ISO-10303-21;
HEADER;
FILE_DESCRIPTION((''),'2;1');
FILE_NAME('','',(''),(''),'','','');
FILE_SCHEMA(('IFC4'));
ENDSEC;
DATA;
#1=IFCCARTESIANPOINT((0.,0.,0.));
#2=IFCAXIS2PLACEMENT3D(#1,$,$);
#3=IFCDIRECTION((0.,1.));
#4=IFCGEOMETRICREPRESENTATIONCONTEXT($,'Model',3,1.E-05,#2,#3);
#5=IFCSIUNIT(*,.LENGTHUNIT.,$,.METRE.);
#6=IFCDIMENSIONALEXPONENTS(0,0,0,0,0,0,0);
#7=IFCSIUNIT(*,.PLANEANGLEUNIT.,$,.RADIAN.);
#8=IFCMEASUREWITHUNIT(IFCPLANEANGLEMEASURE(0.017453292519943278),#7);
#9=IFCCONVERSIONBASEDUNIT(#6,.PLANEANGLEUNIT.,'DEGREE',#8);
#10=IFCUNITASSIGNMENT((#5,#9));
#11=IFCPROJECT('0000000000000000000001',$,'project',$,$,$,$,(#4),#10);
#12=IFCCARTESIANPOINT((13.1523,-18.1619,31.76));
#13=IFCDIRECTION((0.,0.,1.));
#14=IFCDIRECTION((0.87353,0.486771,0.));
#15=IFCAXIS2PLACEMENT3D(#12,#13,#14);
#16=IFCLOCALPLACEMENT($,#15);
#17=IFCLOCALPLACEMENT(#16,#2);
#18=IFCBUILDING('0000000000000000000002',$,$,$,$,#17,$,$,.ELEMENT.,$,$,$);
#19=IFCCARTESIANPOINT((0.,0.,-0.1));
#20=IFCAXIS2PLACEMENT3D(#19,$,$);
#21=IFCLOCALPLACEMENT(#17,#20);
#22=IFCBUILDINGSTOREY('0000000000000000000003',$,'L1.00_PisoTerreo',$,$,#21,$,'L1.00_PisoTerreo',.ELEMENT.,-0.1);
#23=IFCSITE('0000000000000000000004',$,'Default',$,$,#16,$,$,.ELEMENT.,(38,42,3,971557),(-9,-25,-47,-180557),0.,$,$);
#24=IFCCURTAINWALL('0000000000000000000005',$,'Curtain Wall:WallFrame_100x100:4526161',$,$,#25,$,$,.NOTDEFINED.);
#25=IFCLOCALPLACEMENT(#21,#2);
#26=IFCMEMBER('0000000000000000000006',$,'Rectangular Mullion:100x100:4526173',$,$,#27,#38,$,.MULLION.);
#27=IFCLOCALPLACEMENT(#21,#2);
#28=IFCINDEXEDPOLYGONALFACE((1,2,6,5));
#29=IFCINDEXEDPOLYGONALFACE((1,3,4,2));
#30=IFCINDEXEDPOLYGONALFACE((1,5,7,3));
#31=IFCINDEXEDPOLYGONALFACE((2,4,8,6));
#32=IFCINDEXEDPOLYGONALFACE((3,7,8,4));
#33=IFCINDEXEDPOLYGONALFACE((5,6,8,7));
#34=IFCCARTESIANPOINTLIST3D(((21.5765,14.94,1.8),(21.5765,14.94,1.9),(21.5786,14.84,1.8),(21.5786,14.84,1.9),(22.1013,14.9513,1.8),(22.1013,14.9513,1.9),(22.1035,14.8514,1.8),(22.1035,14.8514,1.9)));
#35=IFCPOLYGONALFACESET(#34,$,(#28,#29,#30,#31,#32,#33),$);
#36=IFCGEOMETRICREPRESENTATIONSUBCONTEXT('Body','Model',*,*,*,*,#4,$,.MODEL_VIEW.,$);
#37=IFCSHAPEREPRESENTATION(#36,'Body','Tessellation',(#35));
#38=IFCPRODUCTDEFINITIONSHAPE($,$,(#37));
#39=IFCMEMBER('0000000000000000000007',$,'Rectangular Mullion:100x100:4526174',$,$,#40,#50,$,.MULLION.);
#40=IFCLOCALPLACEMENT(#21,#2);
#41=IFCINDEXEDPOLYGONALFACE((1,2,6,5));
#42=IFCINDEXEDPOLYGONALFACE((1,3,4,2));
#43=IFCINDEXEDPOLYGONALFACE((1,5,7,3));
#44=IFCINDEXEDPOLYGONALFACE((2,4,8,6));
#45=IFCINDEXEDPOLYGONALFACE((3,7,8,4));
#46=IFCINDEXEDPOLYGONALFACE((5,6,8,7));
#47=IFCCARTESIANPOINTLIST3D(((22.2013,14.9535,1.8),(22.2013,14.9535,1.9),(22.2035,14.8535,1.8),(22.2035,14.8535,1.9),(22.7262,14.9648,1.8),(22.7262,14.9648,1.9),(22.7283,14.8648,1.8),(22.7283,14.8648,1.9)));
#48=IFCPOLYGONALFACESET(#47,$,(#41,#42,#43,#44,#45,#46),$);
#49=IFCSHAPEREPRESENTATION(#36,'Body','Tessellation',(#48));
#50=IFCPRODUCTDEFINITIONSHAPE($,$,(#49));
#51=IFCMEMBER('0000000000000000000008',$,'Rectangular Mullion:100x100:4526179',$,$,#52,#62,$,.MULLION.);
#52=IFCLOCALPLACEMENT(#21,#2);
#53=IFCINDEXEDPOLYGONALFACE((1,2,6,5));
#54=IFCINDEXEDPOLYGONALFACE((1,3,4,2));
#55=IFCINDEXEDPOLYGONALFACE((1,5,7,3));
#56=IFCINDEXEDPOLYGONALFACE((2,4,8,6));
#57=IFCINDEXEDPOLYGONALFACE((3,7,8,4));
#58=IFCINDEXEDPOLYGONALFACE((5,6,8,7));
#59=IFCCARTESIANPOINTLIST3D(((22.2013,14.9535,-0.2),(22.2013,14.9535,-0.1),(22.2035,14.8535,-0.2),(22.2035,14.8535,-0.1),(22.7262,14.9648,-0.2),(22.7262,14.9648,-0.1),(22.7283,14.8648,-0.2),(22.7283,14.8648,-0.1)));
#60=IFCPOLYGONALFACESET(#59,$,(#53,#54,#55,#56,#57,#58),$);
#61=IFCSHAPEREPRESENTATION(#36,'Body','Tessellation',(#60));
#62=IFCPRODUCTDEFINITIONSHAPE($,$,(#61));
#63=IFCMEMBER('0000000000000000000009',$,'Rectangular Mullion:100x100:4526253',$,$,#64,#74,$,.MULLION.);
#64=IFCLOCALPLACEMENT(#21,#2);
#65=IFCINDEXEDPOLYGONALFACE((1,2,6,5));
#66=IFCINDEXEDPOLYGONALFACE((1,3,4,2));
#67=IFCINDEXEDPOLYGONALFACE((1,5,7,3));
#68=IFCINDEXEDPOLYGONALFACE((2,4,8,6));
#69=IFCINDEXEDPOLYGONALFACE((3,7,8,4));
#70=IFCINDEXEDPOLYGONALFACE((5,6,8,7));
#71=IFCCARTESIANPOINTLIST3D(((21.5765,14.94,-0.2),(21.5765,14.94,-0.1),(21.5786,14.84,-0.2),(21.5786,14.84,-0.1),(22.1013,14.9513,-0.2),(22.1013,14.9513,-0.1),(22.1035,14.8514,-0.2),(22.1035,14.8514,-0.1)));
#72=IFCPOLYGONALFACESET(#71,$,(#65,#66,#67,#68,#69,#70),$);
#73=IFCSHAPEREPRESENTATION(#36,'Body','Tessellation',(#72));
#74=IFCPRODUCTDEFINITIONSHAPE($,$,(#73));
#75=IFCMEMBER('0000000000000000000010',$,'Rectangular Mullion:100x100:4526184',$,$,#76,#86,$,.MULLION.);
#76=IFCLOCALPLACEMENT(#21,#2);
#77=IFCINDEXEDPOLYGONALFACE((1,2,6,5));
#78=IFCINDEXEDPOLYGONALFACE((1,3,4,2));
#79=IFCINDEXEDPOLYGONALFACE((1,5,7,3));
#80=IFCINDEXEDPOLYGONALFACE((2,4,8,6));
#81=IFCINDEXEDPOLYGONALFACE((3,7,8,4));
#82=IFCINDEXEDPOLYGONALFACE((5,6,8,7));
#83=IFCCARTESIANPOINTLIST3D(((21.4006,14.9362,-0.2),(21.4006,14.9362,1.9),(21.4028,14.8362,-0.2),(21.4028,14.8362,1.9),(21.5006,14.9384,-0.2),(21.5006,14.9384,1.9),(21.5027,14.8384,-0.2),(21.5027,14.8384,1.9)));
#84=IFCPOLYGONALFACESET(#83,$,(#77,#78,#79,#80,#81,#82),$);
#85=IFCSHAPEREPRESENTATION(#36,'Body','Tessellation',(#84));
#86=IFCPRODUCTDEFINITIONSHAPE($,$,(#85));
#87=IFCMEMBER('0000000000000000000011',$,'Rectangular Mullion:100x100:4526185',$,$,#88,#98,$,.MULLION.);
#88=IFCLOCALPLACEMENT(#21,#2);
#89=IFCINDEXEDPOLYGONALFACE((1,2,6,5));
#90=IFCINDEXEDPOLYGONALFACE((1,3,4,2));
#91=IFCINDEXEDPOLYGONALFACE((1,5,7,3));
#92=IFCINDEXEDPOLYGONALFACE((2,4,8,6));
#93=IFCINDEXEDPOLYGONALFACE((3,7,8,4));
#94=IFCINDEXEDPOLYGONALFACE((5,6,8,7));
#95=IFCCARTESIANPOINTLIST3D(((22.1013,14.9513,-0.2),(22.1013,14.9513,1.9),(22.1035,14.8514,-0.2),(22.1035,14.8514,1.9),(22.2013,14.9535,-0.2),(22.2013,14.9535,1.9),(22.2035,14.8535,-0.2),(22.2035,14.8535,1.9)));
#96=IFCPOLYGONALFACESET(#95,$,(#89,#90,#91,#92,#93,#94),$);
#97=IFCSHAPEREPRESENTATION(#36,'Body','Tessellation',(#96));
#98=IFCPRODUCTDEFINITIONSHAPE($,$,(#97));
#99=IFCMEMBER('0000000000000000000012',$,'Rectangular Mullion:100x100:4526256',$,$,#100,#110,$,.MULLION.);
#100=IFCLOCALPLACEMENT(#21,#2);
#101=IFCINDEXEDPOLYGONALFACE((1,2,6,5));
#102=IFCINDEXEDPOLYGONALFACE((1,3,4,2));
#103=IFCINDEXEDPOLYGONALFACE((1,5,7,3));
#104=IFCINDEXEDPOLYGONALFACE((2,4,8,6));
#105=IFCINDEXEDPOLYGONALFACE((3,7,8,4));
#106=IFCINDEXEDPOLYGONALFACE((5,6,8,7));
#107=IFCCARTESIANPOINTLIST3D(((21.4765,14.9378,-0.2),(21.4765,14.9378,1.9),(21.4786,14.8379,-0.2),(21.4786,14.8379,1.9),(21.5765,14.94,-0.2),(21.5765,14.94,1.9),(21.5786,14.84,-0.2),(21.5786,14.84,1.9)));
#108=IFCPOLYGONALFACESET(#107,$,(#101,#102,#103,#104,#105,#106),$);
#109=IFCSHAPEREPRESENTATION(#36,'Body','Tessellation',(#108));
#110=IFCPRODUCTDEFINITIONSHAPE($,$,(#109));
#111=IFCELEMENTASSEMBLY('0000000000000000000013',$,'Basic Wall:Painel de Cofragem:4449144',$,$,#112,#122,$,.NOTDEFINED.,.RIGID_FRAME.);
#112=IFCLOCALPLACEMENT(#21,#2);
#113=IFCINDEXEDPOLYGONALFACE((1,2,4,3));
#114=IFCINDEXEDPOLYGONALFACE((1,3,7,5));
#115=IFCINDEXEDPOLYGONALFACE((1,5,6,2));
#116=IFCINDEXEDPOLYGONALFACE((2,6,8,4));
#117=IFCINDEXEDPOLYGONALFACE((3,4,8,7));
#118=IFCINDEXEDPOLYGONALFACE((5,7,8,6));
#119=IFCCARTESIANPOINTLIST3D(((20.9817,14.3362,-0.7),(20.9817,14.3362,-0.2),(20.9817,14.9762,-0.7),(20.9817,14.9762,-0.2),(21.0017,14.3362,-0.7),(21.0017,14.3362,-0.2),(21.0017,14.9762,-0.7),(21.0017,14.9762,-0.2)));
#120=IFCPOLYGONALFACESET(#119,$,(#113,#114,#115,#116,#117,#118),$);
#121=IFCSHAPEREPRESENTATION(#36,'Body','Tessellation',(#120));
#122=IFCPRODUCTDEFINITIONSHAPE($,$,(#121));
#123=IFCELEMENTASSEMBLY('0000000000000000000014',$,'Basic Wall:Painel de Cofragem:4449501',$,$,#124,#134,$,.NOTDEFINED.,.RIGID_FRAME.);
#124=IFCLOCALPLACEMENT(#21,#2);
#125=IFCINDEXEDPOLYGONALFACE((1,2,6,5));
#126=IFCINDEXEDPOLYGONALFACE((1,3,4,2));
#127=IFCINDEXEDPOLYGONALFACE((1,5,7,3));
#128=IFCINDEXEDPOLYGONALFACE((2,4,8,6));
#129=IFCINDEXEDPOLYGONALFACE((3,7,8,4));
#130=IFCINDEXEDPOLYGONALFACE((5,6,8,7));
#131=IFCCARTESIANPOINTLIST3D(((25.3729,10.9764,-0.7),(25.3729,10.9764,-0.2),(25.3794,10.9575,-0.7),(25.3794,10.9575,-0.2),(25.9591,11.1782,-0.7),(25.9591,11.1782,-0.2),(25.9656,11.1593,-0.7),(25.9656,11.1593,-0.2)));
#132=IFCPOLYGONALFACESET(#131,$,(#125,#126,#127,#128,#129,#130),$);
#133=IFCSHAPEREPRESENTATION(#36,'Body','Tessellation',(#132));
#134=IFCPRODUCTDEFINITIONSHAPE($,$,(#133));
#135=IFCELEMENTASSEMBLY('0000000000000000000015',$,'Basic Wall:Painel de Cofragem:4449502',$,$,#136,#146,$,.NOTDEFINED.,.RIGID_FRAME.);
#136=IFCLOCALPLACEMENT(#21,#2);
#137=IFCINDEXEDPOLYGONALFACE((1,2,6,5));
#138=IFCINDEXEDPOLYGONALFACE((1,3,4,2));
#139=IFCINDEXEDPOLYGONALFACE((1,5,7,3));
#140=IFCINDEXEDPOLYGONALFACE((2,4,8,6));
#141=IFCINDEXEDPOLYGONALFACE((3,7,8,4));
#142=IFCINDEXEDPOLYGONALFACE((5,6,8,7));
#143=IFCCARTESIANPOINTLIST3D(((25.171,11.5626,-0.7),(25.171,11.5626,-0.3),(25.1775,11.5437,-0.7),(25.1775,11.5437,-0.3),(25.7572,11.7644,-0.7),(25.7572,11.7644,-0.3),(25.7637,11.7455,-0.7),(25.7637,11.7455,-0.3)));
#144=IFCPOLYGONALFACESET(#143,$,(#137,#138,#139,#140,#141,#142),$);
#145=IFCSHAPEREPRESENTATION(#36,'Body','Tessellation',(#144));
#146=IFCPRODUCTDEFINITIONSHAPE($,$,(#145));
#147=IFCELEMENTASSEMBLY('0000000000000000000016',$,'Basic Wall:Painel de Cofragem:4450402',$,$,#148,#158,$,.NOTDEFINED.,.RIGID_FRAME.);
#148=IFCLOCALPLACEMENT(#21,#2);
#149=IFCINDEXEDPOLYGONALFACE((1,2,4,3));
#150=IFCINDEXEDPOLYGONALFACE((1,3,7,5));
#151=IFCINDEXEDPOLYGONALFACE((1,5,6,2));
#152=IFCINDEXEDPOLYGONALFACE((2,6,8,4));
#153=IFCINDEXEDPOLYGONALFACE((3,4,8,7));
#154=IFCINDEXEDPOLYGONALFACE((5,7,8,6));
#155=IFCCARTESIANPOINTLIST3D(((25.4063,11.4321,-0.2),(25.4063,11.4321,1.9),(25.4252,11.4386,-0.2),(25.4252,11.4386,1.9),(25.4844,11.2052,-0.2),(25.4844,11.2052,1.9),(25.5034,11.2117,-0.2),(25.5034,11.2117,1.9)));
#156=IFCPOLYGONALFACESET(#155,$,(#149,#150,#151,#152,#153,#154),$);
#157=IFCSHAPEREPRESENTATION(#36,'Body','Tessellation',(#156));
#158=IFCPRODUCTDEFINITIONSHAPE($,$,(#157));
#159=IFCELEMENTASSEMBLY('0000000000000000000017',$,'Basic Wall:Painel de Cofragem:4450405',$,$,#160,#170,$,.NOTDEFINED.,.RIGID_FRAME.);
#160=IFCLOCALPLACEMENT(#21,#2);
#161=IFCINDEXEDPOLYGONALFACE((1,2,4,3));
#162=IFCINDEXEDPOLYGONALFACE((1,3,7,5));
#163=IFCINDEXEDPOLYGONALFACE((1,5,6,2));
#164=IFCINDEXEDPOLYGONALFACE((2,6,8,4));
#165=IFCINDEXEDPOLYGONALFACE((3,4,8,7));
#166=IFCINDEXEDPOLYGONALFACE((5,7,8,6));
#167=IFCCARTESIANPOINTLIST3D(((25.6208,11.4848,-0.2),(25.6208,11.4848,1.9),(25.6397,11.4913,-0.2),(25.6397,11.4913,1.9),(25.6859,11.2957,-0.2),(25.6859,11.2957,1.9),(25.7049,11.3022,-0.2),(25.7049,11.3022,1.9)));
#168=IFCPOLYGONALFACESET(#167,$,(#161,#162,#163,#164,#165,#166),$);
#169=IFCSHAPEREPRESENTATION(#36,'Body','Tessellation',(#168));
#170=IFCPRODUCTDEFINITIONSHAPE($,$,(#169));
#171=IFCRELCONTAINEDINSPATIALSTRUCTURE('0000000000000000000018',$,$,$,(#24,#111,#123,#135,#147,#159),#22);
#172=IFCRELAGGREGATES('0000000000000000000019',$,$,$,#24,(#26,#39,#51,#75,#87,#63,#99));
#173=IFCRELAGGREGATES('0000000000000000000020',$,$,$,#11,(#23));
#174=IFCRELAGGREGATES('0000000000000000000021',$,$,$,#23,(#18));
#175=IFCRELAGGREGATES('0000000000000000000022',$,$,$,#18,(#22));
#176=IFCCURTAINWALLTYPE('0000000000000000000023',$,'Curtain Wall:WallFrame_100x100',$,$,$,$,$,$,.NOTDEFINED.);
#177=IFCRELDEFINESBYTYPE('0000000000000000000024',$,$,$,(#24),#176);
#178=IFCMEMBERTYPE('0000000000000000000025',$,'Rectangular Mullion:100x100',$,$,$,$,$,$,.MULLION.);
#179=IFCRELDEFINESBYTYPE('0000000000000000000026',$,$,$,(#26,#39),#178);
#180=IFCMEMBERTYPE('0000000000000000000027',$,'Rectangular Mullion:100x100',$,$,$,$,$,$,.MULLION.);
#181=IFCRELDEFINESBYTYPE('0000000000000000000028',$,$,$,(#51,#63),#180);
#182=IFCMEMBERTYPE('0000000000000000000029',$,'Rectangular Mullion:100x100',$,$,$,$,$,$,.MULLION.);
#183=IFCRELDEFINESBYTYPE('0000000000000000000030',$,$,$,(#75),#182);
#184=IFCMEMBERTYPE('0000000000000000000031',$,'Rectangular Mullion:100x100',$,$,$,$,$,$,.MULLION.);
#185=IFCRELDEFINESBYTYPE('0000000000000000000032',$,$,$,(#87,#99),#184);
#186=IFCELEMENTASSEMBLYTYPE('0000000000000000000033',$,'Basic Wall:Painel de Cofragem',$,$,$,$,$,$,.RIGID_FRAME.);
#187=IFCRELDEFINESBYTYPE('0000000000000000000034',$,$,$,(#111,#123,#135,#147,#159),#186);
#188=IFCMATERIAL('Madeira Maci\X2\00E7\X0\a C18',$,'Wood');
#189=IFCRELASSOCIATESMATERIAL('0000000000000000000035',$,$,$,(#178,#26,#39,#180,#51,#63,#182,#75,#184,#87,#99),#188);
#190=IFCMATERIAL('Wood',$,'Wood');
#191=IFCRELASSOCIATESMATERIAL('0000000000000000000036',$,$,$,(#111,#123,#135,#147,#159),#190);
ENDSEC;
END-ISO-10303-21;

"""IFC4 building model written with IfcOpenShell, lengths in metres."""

from ifc_helpers import new_model, entity, si_unit, converted_unit, direction, frame, origin, place, context, subcontext, project, spatial, indexed_curve, outline, extrude, source, transform, mapped, material, type_object, type_shapes, element, aggregate, save


model = new_model("IFC4")

# Units and contexts
model_context = context("Model", 3, precision=1e-05, world=origin(), true_north=direction((0.0, 1.0)))
body_context = subcontext(model_context, "Body", "Model", "MODEL_VIEW")
ifc_project = project(units=[si_unit("LENGTHUNIT", "METRE"), converted_unit("PLANEANGLEUNIT", "DEGREE", entity("IfcPlaneAngleMeasure", 0.017453292519943278), si_unit("PLANEANGLEUNIT", "RADIAN"), dimensions=[0, 0, 0, 0, 0, 0, 0])], contexts=[model_context])

# Site, building, storey
site_placement = place(None, frame((13.1523, -18.1619, 31.76), z_axis=(0.0, 0.0, 1.0), x_axis=(0.87353, 0.486771, 0.0)))
site = spatial("IfcSite", under=ifc_project, at=site_placement, Name="Default", CompositionType="ELEMENT", RefLatitude=(38, 42, 3, 971557), RefLongitude=(-9, -25, -47, -180557), RefElevation=0.0)
building_placement = place(site_placement, origin())
building = spatial("IfcBuilding", under=site, at=building_placement, CompositionType="ELEMENT")
storey_placement = place(building_placement, frame((0.0, 0.0, -0.1)))
storey = spatial("IfcBuildingStorey", under=building, at=storey_placement, Name="L1.00_PisoTerreo", LongName="L1.00_PisoTerreo", CompositionType="ELEMENT", Elevation=-0.1)

# Curtain wall, members
curtain_wall_type = type_object("IfcCurtainWallType", Name="Curtain Wall:WallFrame_100x100", PredefinedType="NOTDEFINED")
curtain_wall_placement = place(storey_placement, frame((0.0, 0.0, 0.1)))
curtain_wall = element("IfcCurtainWall", 1, at=curtain_wall_placement, inside=storey, type_object=curtain_wall_type, Name="Curtain Wall:WallFrame_100x100:4526161", PredefinedType="NOTDEFINED")
ifc_material_1 = material(Name="Madeira Maciça C18", Category="Wood")
member_type_1 = type_object("IfcMemberType", Name="Rectangular Mullion:100x100", PredefinedType="MULLION", material=ifc_material_1)
shared_shape_1 = source(origin(), body_context, "Body", "SweptSolid", [
    extrude(outline(indexed_curve([(-0.05, -0.05), (0.05, -0.05), (0.05, 0.05), (-0.05, 0.05), (-0.05, -0.05)], self_intersect=False)), frame((-0.05, 0.0, -0.525), z_axis=(0.0, 0.0, 1.0), x_axis=(-1.0, 0.0, 0.0)), (0.0, 0.0, 1.0), 0.525),
])
type_shapes(member_type_1, [shared_shape_1])
member_1_placement = place(curtain_wall_placement, frame((22.1024, 14.9013, 1.8), z_axis=(0.999767, 0.021581, 0.0), x_axis=(0.0, 0.0, 1.0)))
member_1 = element("IfcMember", 2, at=member_1_placement, type_object=member_type_1, material=ifc_material_1, Name="Rectangular Mullion:100x100:4526173", PredefinedType="MULLION", context=body_context, shape_type="MappedRepresentation", body=[
    mapped(shared_shape_1, transform((0.0, 0.0, 0.0), scale=1.0)),
])
member_2_placement = place(curtain_wall_placement, frame((22.7273, 14.9148, 1.8), z_axis=(0.999767, 0.021581, 0.0), x_axis=(0.0, 0.0, 1.0)))
member_2 = element("IfcMember", 3, at=member_2_placement, type_object=member_type_1, material=ifc_material_1, Name="Rectangular Mullion:100x100:4526174", PredefinedType="MULLION", context=body_context, shape_type="MappedRepresentation", body=[
    mapped(shared_shape_1, transform((0.0, 0.0, 0.0), scale=1.0)),
])
member_type_2 = type_object("IfcMemberType", Name="Rectangular Mullion:100x100", PredefinedType="MULLION", material=ifc_material_1)
shared_shape_2 = source(origin(), body_context, "Body", "SweptSolid", [
    extrude(outline(indexed_curve([(-0.05, -0.05), (0.05, -0.05), (0.05, 0.05), (-0.05, 0.05), (-0.05, -0.05)], self_intersect=False)), frame((-0.05, 0.0, -0.525), z_axis=(0.0, 0.0, 1.0), x_axis=(0.0, -1.0, 0.0)), (0.0, 0.0, 1.0), 0.525),
])
type_shapes(member_type_2, [shared_shape_2])
member_3_placement = place(curtain_wall_placement, frame((22.2024, 14.9035, -0.3), z_axis=(-0.999767, -0.021581, 0.0), x_axis=(0.0, 0.0, -1.0)))
member_3 = element("IfcMember", 4, at=member_3_placement, type_object=member_type_2, material=ifc_material_1, Name="Rectangular Mullion:100x100:4526179", PredefinedType="MULLION", context=body_context, shape_type="MappedRepresentation", body=[
    mapped(shared_shape_2, transform((0.0, 0.0, 0.0), scale=1.0)),
])
member_4_placement = place(curtain_wall_placement, frame((21.5775, 14.89, -0.3), z_axis=(-0.999767, -0.021581, 0.0), x_axis=(0.0, 0.0, -1.0)))
member_4 = element("IfcMember", 5, at=member_4_placement, type_object=member_type_2, material=ifc_material_1, Name="Rectangular Mullion:100x100:4526253", PredefinedType="MULLION", context=body_context, shape_type="MappedRepresentation", body=[
    mapped(shared_shape_2, transform((0.0, 0.0, 0.0), scale=1.0)),
])
member_type_3 = type_object("IfcMemberType", Name="Rectangular Mullion:100x100", PredefinedType="MULLION", material=ifc_material_1)
shared_shape_3 = source(origin(), body_context, "Body", "SweptSolid", [
    extrude(outline(indexed_curve([(-0.05, -0.05), (0.05, -0.05), (0.05, 0.05), (-0.05, 0.05), (-0.05, -0.05)], self_intersect=False)), frame((-0.05, 0.0, -2.1), z_axis=(0.0, 0.0, 1.0), x_axis=(0.0, -1.0, 0.0)), (0.0, 0.0, 1.0), 2.1),
])
type_shapes(member_type_3, [shared_shape_3])
member_5_placement = place(curtain_wall_placement, frame((21.4017, 14.8862, 1.8), z_axis=(0.0, 0.0, 1.0), x_axis=(-0.999767, -0.021581, 0.0)))
member_5 = element("IfcMember", 6, at=member_5_placement, type_object=member_type_3, material=ifc_material_1, Name="Rectangular Mullion:100x100:4526184", PredefinedType="MULLION", context=body_context, shape_type="MappedRepresentation", body=[
    mapped(shared_shape_3, transform((0.0, 0.0, 0.0), scale=1.0)),
])
member_type_4 = type_object("IfcMemberType", Name="Rectangular Mullion:100x100", PredefinedType="MULLION", material=ifc_material_1)
shared_shape_4 = source(origin(), body_context, "Body", "SweptSolid", [
    extrude(outline(indexed_curve([(-0.05, -0.05), (0.05, -0.05), (0.05, 0.05), (-0.05, 0.05), (-0.05, -0.05)], self_intersect=False)), frame((0.0, 0.0, -2.1), z_axis=(0.0, 0.0, 1.0), x_axis=(-1.0, 0.0, 0.0)), (0.0, 0.0, 1.0), 2.1),
])
type_shapes(member_type_4, [shared_shape_4])
member_6_placement = place(curtain_wall_placement, frame((22.1524, 14.9024, -0.3), z_axis=(0.0, 0.0, -1.0), x_axis=(0.999767, 0.021581, 0.0)))
member_6 = element("IfcMember", 7, at=member_6_placement, type_object=member_type_4, material=ifc_material_1, Name="Rectangular Mullion:100x100:4526185", PredefinedType="MULLION", context=body_context, shape_type="MappedRepresentation", body=[
    mapped(shared_shape_4, transform((0.0, 0.0, 0.0), scale=1.0)),
])
member_7_placement = place(curtain_wall_placement, frame((21.5275, 14.8889, -0.3), z_axis=(0.0, 0.0, -1.0), x_axis=(0.999767, 0.021581, 0.0)))
member_7 = element("IfcMember", 8, at=member_7_placement, type_object=member_type_4, material=ifc_material_1, Name="Rectangular Mullion:100x100:4526256", PredefinedType="MULLION", context=body_context, shape_type="MappedRepresentation", body=[
    mapped(shared_shape_4, transform((0.0, 0.0, 0.0), scale=1.0)),
])
aggregate(curtain_wall, [member_1, member_2, member_3, member_5, member_6, member_4, member_7])

# Element assemblies
ifc_material_2 = material(Name="Wood", Category="Wood")
element_assembly_type = type_object("IfcElementAssemblyType", Name="Basic Wall:Painel de Cofragem", PredefinedType="RIGID_FRAME")
assembly_1_placement = place(storey_placement, frame((20.9917, 14.3362, -0.7), z_axis=(0.0, 0.0, 1.0), x_axis=(0.0, 1.0, 0.0)))
element("IfcElementAssembly", 9, at=assembly_1_placement, inside=storey, type_object=element_assembly_type, material=ifc_material_2, Name="Basic Wall:Painel de Cofragem:4449144", AssemblyPlace="NOTDEFINED", PredefinedType="RIGID_FRAME", context=body_context, shape_type="SweptSolid", body=[
    extrude(outline(indexed_curve([(0.64, 0.01), (0.0, 0.01), (0.0, -0.01), (0.64, -0.01), (0.64, 0.01)], self_intersect=False)), origin(), (0.0, 0.0, 1.0), 0.5),
])
assembly_2_placement = place(storey_placement, frame((25.3761, 10.9669, -0.7), z_axis=(0.0, 0.0, 1.0), x_axis=(0.945519, 0.325568, 0.0)))
element("IfcElementAssembly", 10, at=assembly_2_placement, inside=storey, type_object=element_assembly_type, material=ifc_material_2, Name="Basic Wall:Painel de Cofragem:4449501", AssemblyPlace="NOTDEFINED", PredefinedType="RIGID_FRAME", context=body_context, shape_type="SweptSolid", body=[
    extrude(outline(indexed_curve([(0.62, 0.01), (0.0, 0.01), (0.0, -0.01), (0.62, -0.01), (0.62, 0.01)], self_intersect=False)), origin(), (0.0, 0.0, 1.0), 0.5),
])
assembly_3_placement = place(storey_placement, frame((25.1743, 11.5531, -0.7), z_axis=(0.0, 0.0, 1.0), x_axis=(0.945519, 0.325568, 0.0)))
element("IfcElementAssembly", 11, at=assembly_3_placement, inside=storey, type_object=element_assembly_type, material=ifc_material_2, Name="Basic Wall:Painel de Cofragem:4449502", AssemblyPlace="NOTDEFINED", PredefinedType="RIGID_FRAME", context=body_context, shape_type="SweptSolid", body=[
    extrude(outline(indexed_curve([(0.62, 0.01), (0.0, 0.01), (0.0, -0.01), (0.62, -0.01), (0.62, 0.01)], self_intersect=False)), origin(), (0.0, 0.0, 1.0), 0.4),
])
assembly_4_placement = place(storey_placement, frame((25.4158, 11.4353, -0.2), z_axis=(0.0, 0.0, 1.0), x_axis=(0.325568, -0.945519, 0.0)))
element("IfcElementAssembly", 12, at=assembly_4_placement, inside=storey, type_object=element_assembly_type, material=ifc_material_2, Name="Basic Wall:Painel de Cofragem:4450402", AssemblyPlace="NOTDEFINED", PredefinedType="RIGID_FRAME", context=body_context, shape_type="SweptSolid", body=[
    extrude(outline(indexed_curve([(0.24, 0.01), (0.0, 0.01), (0.0, -0.01), (0.24, -0.01), (0.24, 0.01)], self_intersect=False)), origin(), (0.0, 0.0, 1.0), 2.1),
])
assembly_5_placement = place(storey_placement, frame((25.6303, 11.4881, -0.2), z_axis=(0.0, 0.0, 1.0), x_axis=(0.325568, -0.945519, 0.0)))
element("IfcElementAssembly", 13, at=assembly_5_placement, inside=storey, type_object=element_assembly_type, material=ifc_material_2, Name="Basic Wall:Painel de Cofragem:4450405", AssemblyPlace="NOTDEFINED", PredefinedType="RIGID_FRAME", context=body_context, shape_type="SweptSolid", body=[
    extrude(outline(indexed_curve([(0.2, 0.01), (0.0, 0.01), (0.0, -0.01), (0.2, -0.01), (0.2, 0.01)], self_intersect=False)), origin(), (0.0, 0.0, 1.0), 2.1),
])

save(model, "model.ifc")
